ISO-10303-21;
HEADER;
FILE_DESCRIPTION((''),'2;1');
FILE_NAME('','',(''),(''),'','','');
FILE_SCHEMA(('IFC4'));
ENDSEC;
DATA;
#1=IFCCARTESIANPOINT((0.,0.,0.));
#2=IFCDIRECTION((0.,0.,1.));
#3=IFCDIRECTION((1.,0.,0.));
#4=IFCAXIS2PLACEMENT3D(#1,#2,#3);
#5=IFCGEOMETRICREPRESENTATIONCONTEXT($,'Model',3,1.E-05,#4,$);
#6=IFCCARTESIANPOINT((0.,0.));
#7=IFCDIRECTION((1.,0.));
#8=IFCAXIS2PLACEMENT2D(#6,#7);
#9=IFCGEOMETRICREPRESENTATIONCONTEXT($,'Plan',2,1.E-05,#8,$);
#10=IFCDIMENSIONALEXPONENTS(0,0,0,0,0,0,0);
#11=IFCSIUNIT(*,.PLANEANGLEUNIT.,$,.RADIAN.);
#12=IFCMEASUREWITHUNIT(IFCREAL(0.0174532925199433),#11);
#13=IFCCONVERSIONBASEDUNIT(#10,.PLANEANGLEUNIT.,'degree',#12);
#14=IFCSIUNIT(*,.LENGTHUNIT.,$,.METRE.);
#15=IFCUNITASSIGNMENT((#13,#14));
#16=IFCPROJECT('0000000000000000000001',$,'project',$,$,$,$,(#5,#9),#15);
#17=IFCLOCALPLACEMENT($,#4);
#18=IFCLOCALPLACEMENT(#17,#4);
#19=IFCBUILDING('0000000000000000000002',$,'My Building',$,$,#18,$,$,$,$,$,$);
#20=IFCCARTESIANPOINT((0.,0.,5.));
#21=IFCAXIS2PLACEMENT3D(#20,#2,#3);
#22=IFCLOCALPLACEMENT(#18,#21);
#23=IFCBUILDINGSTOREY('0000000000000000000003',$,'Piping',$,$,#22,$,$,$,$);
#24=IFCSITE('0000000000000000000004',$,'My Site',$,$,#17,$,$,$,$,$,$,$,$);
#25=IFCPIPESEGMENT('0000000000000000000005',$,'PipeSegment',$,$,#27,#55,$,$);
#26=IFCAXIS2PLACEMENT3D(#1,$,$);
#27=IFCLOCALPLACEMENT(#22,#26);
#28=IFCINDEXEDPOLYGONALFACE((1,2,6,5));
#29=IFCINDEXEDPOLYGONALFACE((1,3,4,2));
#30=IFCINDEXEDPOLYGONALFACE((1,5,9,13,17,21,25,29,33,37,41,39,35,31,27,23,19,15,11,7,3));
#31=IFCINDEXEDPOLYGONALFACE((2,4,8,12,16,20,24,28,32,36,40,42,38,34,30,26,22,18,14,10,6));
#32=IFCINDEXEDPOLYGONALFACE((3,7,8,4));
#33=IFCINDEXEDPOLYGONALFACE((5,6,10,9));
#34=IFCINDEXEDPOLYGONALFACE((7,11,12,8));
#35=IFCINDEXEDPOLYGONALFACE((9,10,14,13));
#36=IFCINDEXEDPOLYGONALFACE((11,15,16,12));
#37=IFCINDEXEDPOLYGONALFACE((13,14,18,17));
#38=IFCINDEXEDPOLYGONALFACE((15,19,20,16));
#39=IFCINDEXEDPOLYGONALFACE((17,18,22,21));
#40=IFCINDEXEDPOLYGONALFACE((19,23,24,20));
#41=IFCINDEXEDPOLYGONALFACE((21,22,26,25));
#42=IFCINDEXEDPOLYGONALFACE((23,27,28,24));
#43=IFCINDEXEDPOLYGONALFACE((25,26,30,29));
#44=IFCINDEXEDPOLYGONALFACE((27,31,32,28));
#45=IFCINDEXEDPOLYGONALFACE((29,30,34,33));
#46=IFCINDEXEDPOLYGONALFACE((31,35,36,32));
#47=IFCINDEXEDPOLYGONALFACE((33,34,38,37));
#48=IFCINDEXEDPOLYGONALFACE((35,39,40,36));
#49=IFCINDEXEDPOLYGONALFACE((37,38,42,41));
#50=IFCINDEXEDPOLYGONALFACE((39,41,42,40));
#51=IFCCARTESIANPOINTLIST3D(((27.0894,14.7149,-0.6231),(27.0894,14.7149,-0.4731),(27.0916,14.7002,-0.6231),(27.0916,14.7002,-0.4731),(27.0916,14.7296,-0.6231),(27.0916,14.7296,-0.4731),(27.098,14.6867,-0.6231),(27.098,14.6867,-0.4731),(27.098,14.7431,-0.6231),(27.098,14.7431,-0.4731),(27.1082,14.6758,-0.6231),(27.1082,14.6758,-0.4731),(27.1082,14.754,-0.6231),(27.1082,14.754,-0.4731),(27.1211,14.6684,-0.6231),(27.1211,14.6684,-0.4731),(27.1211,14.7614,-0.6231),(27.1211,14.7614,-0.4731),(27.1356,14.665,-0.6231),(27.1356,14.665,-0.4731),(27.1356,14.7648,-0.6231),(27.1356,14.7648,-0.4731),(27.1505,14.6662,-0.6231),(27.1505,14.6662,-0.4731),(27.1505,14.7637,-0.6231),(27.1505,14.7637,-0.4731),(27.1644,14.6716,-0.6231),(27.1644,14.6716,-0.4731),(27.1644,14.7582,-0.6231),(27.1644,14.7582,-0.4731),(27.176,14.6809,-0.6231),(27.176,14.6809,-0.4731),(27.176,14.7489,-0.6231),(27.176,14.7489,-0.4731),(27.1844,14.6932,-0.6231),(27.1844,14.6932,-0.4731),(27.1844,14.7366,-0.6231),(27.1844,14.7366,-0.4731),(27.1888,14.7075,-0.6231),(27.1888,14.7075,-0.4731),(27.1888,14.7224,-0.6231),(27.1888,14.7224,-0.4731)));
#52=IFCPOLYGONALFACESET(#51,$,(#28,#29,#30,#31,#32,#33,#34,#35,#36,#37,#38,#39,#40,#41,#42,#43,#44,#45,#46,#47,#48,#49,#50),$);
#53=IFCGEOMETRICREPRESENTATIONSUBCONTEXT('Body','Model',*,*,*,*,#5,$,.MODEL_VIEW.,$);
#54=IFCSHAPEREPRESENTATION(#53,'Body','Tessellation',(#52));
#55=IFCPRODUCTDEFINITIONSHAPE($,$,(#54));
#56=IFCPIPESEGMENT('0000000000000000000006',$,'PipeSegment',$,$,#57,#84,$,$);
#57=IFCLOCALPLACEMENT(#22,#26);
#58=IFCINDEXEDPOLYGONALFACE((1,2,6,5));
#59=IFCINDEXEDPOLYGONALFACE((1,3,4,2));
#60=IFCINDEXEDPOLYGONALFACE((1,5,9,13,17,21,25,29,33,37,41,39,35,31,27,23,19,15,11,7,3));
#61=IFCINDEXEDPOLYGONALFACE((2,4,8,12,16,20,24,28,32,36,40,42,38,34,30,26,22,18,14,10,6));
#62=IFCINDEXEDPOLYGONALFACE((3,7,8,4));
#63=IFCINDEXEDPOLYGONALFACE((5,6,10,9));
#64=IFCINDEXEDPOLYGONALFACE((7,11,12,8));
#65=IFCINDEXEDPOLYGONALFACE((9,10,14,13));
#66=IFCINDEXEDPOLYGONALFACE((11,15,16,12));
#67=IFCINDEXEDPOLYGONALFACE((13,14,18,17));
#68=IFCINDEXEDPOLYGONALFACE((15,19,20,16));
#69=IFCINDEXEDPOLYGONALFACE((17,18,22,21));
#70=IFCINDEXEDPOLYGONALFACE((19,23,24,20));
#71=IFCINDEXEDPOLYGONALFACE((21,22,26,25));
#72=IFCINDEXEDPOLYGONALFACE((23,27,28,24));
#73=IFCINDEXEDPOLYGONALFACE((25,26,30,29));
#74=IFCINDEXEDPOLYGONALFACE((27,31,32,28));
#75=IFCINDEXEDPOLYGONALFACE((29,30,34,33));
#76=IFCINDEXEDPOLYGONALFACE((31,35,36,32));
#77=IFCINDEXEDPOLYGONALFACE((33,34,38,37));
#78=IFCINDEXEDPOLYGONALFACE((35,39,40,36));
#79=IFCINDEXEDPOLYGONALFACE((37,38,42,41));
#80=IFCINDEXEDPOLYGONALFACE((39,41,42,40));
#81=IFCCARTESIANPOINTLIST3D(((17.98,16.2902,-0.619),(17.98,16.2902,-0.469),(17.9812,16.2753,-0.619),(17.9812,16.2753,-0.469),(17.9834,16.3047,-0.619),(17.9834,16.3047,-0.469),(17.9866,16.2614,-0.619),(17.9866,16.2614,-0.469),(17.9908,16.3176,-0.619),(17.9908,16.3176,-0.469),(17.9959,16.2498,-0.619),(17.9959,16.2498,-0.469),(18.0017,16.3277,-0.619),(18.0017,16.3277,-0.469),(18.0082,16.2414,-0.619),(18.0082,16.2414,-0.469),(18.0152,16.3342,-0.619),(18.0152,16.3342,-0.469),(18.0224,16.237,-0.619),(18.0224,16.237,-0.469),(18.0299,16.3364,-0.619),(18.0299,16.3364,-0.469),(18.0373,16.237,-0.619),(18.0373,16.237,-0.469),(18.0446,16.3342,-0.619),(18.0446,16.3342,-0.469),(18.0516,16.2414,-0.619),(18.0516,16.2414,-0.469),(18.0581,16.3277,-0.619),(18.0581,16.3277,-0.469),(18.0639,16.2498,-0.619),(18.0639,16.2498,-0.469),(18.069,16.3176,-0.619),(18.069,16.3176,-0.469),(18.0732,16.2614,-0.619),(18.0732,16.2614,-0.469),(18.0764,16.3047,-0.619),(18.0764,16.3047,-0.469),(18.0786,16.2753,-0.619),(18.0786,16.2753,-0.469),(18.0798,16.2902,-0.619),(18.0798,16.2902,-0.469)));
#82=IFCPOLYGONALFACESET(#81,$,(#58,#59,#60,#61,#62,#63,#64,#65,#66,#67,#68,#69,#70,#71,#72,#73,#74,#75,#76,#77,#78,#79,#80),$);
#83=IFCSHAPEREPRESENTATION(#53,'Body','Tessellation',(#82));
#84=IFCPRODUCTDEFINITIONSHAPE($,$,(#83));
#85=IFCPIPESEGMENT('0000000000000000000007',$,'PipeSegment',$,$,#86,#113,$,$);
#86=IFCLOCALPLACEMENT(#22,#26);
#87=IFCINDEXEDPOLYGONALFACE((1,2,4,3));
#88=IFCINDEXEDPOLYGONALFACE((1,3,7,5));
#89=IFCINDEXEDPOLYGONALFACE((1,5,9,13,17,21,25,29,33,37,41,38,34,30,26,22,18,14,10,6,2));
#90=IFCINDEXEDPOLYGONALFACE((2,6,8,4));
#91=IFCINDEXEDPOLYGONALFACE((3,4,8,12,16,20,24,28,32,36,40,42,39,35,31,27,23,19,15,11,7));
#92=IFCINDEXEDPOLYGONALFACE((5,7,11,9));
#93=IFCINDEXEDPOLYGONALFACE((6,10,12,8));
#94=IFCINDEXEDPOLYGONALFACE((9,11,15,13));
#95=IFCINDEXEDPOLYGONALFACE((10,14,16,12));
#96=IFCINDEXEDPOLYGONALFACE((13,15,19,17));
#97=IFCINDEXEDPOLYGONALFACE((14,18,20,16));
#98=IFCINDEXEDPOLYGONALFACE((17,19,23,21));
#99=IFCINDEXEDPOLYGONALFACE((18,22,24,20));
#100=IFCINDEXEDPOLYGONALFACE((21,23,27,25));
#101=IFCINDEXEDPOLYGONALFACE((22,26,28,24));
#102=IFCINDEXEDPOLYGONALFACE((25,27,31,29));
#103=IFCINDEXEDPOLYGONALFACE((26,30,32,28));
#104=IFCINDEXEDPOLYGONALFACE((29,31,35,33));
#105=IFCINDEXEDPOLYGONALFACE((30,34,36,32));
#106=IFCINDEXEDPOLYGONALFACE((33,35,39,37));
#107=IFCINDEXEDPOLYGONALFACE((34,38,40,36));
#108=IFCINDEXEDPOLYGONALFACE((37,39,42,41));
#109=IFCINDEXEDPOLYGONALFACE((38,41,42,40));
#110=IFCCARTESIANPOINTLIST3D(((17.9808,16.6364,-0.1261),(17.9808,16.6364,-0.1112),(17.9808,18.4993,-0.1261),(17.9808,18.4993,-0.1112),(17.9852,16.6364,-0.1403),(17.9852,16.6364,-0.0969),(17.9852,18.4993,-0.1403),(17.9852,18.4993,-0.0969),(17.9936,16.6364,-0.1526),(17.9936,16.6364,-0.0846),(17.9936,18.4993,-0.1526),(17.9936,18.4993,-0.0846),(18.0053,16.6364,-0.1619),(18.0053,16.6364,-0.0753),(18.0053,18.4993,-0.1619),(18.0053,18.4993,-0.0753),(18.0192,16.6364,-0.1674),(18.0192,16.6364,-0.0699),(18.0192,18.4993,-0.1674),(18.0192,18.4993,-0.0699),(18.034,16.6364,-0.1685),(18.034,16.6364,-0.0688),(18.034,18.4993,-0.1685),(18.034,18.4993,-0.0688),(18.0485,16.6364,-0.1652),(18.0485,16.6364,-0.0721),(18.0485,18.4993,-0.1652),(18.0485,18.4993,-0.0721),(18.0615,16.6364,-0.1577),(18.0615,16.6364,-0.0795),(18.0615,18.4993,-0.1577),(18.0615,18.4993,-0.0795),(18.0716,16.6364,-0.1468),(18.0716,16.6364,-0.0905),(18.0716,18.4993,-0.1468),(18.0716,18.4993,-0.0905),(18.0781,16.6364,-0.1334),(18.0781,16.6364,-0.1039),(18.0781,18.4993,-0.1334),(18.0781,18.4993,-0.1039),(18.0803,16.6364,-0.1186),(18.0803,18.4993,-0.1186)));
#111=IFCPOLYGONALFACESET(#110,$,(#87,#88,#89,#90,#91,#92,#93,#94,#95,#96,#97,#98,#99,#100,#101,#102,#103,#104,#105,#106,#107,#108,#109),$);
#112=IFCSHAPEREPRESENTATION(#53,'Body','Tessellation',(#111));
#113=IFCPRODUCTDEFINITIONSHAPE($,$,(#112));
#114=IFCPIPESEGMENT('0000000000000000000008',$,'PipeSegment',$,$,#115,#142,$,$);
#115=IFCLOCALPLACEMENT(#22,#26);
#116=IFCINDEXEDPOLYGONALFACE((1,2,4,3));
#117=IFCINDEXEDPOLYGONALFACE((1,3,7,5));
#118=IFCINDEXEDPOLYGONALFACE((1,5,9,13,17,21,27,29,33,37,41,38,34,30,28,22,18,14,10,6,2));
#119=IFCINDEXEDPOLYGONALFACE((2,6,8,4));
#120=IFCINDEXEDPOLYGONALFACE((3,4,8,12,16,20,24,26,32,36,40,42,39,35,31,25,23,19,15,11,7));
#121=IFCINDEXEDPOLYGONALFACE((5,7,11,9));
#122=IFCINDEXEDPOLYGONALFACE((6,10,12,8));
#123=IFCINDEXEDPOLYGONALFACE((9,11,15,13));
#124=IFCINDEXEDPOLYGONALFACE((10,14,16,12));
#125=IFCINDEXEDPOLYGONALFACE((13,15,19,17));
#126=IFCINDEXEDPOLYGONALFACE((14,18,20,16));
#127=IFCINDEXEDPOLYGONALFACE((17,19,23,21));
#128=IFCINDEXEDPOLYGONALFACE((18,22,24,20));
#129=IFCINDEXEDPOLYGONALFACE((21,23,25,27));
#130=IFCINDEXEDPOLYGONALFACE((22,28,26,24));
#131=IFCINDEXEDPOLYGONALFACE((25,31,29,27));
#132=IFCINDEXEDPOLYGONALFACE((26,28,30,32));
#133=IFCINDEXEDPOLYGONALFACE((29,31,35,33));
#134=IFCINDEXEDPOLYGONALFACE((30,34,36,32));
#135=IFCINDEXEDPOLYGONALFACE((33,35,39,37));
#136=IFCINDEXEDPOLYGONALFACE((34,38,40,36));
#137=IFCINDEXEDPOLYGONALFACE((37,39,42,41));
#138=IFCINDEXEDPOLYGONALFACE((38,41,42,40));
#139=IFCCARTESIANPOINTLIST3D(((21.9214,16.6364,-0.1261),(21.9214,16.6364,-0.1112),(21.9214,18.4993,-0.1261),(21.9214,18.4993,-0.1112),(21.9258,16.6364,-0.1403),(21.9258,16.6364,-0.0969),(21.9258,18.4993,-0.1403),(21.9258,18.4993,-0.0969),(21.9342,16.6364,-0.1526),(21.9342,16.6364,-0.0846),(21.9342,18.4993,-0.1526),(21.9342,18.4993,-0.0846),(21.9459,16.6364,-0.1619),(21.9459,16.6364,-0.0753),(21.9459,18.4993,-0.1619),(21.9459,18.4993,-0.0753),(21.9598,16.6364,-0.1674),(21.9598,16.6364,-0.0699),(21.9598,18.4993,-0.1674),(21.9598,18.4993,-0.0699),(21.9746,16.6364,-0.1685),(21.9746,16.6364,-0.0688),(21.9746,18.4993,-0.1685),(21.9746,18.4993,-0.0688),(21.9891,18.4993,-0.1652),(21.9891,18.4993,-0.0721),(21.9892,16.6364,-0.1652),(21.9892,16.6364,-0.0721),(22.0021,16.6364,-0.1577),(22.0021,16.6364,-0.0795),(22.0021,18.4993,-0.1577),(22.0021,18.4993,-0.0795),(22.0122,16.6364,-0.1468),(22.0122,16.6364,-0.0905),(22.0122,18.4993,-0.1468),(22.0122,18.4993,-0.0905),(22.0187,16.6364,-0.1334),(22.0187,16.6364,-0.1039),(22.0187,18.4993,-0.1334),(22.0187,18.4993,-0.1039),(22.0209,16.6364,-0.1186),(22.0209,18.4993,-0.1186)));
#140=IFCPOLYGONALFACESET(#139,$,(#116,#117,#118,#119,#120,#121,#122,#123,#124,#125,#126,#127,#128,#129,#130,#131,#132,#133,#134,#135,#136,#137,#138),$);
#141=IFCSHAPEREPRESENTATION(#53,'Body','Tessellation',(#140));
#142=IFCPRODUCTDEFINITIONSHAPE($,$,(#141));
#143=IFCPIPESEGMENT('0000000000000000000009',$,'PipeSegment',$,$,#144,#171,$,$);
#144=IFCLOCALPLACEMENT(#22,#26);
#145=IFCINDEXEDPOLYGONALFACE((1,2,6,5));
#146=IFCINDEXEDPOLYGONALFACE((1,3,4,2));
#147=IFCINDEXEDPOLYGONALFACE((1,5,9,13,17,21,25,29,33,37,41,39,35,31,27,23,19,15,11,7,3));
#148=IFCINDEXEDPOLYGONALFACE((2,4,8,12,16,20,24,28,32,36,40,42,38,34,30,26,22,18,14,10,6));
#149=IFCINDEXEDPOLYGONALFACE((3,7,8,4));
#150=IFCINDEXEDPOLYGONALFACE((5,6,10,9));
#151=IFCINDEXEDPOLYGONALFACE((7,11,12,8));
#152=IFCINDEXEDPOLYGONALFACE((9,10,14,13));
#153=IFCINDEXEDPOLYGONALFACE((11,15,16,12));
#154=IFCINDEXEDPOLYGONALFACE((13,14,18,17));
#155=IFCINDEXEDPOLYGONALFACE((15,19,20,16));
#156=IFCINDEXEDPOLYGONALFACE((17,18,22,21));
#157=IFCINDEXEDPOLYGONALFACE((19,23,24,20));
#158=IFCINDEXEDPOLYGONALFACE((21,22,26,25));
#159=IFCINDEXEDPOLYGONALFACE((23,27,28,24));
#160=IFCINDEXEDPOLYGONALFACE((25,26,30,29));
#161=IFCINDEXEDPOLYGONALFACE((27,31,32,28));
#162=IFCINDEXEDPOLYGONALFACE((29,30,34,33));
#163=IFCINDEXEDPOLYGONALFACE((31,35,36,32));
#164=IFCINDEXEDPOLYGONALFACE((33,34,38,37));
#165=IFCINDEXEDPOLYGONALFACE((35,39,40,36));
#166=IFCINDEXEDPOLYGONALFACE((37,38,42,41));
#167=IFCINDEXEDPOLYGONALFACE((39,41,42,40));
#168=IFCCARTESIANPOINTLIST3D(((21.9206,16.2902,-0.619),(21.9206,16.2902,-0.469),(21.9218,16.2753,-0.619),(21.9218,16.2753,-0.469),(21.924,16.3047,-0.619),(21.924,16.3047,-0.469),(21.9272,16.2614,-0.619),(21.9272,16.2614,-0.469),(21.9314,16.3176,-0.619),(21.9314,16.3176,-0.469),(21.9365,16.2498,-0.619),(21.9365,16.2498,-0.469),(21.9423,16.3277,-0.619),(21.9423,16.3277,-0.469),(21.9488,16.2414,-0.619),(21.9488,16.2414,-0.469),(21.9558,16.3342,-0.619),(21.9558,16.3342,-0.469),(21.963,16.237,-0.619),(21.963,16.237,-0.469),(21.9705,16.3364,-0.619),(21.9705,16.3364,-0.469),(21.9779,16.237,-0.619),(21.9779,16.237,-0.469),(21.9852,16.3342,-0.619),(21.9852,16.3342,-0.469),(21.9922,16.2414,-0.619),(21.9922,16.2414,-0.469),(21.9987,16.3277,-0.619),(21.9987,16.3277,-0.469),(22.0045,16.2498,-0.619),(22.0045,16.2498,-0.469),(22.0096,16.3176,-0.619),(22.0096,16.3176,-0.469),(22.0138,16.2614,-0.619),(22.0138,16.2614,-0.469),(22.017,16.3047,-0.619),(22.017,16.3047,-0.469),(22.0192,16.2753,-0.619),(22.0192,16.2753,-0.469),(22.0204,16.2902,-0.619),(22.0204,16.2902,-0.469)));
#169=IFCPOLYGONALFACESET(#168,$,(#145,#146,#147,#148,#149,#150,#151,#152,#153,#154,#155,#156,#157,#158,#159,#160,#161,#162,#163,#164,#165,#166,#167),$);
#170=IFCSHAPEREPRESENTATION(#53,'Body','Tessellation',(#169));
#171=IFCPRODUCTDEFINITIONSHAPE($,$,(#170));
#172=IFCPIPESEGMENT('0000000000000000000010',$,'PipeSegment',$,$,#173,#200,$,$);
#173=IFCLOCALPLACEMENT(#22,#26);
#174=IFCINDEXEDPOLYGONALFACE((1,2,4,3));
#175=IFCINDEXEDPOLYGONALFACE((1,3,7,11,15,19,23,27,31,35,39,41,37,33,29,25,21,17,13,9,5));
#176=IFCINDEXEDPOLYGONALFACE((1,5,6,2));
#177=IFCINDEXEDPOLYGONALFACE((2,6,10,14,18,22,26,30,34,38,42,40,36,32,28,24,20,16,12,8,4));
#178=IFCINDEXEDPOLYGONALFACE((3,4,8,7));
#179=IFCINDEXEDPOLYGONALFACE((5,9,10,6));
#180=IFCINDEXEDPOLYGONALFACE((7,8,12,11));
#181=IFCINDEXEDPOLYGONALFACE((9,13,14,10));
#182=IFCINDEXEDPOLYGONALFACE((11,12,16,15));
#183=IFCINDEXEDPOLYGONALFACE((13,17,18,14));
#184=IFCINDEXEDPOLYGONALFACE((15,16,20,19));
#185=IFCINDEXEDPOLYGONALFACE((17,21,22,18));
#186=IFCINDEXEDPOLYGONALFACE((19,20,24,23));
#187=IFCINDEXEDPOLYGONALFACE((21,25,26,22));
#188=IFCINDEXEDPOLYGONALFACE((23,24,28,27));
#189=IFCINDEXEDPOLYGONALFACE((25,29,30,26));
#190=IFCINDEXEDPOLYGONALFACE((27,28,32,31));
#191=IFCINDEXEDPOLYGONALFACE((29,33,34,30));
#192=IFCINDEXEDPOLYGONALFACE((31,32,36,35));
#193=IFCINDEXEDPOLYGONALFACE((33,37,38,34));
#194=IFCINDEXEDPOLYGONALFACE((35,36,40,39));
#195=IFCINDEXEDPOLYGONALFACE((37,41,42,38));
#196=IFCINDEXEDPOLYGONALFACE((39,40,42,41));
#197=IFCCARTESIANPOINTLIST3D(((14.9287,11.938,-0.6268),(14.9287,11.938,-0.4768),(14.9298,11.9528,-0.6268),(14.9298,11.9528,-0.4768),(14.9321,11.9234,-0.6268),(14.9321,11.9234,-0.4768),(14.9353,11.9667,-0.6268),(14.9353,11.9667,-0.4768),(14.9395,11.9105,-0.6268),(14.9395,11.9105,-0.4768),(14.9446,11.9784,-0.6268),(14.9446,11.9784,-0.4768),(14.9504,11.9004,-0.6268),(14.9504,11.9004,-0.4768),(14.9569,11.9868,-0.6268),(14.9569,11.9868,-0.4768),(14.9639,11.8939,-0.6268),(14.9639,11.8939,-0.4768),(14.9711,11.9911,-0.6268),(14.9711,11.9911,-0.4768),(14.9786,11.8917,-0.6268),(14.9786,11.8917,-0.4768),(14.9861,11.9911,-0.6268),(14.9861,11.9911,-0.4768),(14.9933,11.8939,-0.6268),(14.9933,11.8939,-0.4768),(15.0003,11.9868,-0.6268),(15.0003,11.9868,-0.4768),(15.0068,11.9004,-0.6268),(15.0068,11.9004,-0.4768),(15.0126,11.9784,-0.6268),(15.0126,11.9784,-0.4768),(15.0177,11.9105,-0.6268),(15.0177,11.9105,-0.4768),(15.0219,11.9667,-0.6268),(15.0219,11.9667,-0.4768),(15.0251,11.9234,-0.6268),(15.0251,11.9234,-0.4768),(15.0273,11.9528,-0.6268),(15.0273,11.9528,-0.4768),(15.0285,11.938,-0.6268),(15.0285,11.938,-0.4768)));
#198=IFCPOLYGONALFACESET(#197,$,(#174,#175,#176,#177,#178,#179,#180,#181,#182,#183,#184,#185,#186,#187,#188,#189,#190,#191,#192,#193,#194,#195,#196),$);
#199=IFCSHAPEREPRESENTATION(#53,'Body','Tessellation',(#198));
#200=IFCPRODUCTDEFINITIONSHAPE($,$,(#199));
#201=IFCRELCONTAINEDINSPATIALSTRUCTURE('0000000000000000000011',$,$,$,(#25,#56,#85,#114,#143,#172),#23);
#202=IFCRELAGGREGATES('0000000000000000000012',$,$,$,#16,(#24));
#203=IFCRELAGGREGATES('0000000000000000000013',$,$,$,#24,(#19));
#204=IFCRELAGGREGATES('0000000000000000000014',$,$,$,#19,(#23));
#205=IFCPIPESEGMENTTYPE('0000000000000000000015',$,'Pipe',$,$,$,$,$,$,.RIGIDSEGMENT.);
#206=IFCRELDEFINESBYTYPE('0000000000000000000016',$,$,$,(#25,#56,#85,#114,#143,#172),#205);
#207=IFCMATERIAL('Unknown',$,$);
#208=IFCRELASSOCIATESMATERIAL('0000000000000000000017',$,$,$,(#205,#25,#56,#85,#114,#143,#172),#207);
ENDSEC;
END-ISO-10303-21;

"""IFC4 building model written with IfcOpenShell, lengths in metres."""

from ifc_helpers import new_model, entity, si_unit, converted_unit, frame, origin_with_axes, origin_2d_with_axis, place, context, subcontext, project, spatial, circle, extrude, material, material_profile, profile_set, profile_usage, type_object, element, save


model = new_model("IFC4")

# Units and contexts
model_context = context("Model", 3, precision=1e-05, world=origin_with_axes())
plan_context = context("Plan", 2, precision=1e-05, world=origin_2d_with_axis())
body_context = subcontext(model_context, "Body", "Model", "MODEL_VIEW")
ifc_project = project(units=[converted_unit("PLANEANGLEUNIT", "degree", entity("IfcReal", 0.0174532925199433), si_unit("PLANEANGLEUNIT", "RADIAN"), dimensions=[0, 0, 0, 0, 0, 0, 0]), si_unit("LENGTHUNIT", "METRE")], contexts=[model_context, plan_context])

# Site, building, storey
site_placement = place(None, origin_with_axes())
site = spatial("IfcSite", under=ifc_project, at=site_placement, Name="My Site")
building_placement = place(site_placement, origin_with_axes())
building = spatial("IfcBuilding", under=site, at=building_placement, Name="My Building")
storey_placement = place(building_placement, frame((0.0, 0.0, 5.0), z_axis=(0.0, 0.0, 1.0), x_axis=(1.0, 0.0, 0.0)))
storey = spatial("IfcBuildingStorey", under=building, at=storey_placement, Name="Piping")

# Pipe segments
ifc_material = material(Name="Unknown")
ifc_material_profile_1 = material_profile(ifc_material, circle(Radius=0.05))
ifc_profile_set_1 = profile_set([ifc_material_profile_1])
pipe_segment_type = type_object("IfcPipeSegmentType", Name="Pipe", PredefinedType="RIGIDSEGMENT", material=ifc_profile_set_1)
ifc_profile_usage_1 = profile_usage(ifc_profile_set_1, cardinal=5)
pipe_segment_1_placement = place(storey_placement, frame((27.1394, 14.7149, -0.4731), z_axis=(0.0, 0.0, -1.0), x_axis=(-1.0, 0.0, 0.0)))
element("IfcPipeSegment", 1, at=pipe_segment_1_placement, inside=storey, type_object=pipe_segment_type, material=ifc_profile_usage_1, Name="PipeSegment", context=body_context, shape_type="SweptSolid", body=[
    extrude(circle(Radius=0.05), origin_with_axes(), (0.0, 0.0, 1.0), 0.15),
])
ifc_profile_usage_2 = profile_usage(ifc_profile_set_1, cardinal=5)
pipe_segment_2_placement = place(storey_placement, frame((18.0299, 16.2864, -0.469), z_axis=(0.0, 0.0, -1.0), x_axis=(0.000053, 1.0, 0.0)))
element("IfcPipeSegment", 2, at=pipe_segment_2_placement, inside=storey, type_object=pipe_segment_type, material=ifc_profile_usage_2, Name="PipeSegment", context=body_context, shape_type="SweptSolid", body=[
    extrude(circle(Radius=0.05), origin_with_axes(), (0.0, 0.0, 1.0), 0.15),
])
ifc_profile_usage_3 = profile_usage(ifc_profile_set_1, cardinal=5)
pipe_segment_3_placement = place(storey_placement, frame((18.0303, 18.4993, -0.1186), z_axis=(0.0, -1.0, 0.0), x_axis=(1.0, 0.0, 0.0)))
element("IfcPipeSegment", 3, at=pipe_segment_3_placement, inside=storey, type_object=pipe_segment_type, material=ifc_profile_usage_3, Name="PipeSegment", context=body_context, shape_type="SweptSolid", body=[
    extrude(circle(Radius=0.05), origin_with_axes(), (0.0, 0.0, 1.0), 1.8629),
])
ifc_profile_usage_4 = profile_usage(ifc_profile_set_1, cardinal=5)
pipe_segment_4_placement = place(storey_placement, frame((21.9709, 18.4993, -0.1186), z_axis=(0.0, -1.0, 0.0), x_axis=(1.0, 0.0, 0.0)))
element("IfcPipeSegment", 4, at=pipe_segment_4_placement, inside=storey, type_object=pipe_segment_type, material=ifc_profile_usage_4, Name="PipeSegment", context=body_context, shape_type="SweptSolid", body=[
    extrude(circle(Radius=0.05), origin_with_axes(), (0.0, 0.0, 1.0), 1.8629),
])
ifc_profile_usage_5 = profile_usage(ifc_profile_set_1, cardinal=5)
pipe_segment_5_placement = place(storey_placement, frame((21.9705, 16.2864, -0.469), z_axis=(0.0, 0.0, -1.0), x_axis=(0.000053, 1.0, 0.0)))
element("IfcPipeSegment", 5, at=pipe_segment_5_placement, inside=storey, type_object=pipe_segment_type, material=ifc_profile_usage_5, Name="PipeSegment", context=body_context, shape_type="SweptSolid", body=[
    extrude(circle(Radius=0.05), origin_with_axes(), (0.0, 0.0, 1.0), 0.15),
])
ifc_profile_usage_6 = profile_usage(ifc_profile_set_1, cardinal=5)
pipe_segment_6_placement = place(storey_placement, frame((14.9786, 11.9417, -0.4768), z_axis=(0.0, 0.0, -1.0), x_axis=(-0.000053, -1.0, 0.0)))
element("IfcPipeSegment", 6, at=pipe_segment_6_placement, inside=storey, type_object=pipe_segment_type, material=ifc_profile_usage_6, Name="PipeSegment", context=body_context, shape_type="SweptSolid", body=[
    extrude(circle(Radius=0.05), origin_with_axes(), (0.0, 0.0, 1.0), 0.15),
])

save(model, "model.ifc")
